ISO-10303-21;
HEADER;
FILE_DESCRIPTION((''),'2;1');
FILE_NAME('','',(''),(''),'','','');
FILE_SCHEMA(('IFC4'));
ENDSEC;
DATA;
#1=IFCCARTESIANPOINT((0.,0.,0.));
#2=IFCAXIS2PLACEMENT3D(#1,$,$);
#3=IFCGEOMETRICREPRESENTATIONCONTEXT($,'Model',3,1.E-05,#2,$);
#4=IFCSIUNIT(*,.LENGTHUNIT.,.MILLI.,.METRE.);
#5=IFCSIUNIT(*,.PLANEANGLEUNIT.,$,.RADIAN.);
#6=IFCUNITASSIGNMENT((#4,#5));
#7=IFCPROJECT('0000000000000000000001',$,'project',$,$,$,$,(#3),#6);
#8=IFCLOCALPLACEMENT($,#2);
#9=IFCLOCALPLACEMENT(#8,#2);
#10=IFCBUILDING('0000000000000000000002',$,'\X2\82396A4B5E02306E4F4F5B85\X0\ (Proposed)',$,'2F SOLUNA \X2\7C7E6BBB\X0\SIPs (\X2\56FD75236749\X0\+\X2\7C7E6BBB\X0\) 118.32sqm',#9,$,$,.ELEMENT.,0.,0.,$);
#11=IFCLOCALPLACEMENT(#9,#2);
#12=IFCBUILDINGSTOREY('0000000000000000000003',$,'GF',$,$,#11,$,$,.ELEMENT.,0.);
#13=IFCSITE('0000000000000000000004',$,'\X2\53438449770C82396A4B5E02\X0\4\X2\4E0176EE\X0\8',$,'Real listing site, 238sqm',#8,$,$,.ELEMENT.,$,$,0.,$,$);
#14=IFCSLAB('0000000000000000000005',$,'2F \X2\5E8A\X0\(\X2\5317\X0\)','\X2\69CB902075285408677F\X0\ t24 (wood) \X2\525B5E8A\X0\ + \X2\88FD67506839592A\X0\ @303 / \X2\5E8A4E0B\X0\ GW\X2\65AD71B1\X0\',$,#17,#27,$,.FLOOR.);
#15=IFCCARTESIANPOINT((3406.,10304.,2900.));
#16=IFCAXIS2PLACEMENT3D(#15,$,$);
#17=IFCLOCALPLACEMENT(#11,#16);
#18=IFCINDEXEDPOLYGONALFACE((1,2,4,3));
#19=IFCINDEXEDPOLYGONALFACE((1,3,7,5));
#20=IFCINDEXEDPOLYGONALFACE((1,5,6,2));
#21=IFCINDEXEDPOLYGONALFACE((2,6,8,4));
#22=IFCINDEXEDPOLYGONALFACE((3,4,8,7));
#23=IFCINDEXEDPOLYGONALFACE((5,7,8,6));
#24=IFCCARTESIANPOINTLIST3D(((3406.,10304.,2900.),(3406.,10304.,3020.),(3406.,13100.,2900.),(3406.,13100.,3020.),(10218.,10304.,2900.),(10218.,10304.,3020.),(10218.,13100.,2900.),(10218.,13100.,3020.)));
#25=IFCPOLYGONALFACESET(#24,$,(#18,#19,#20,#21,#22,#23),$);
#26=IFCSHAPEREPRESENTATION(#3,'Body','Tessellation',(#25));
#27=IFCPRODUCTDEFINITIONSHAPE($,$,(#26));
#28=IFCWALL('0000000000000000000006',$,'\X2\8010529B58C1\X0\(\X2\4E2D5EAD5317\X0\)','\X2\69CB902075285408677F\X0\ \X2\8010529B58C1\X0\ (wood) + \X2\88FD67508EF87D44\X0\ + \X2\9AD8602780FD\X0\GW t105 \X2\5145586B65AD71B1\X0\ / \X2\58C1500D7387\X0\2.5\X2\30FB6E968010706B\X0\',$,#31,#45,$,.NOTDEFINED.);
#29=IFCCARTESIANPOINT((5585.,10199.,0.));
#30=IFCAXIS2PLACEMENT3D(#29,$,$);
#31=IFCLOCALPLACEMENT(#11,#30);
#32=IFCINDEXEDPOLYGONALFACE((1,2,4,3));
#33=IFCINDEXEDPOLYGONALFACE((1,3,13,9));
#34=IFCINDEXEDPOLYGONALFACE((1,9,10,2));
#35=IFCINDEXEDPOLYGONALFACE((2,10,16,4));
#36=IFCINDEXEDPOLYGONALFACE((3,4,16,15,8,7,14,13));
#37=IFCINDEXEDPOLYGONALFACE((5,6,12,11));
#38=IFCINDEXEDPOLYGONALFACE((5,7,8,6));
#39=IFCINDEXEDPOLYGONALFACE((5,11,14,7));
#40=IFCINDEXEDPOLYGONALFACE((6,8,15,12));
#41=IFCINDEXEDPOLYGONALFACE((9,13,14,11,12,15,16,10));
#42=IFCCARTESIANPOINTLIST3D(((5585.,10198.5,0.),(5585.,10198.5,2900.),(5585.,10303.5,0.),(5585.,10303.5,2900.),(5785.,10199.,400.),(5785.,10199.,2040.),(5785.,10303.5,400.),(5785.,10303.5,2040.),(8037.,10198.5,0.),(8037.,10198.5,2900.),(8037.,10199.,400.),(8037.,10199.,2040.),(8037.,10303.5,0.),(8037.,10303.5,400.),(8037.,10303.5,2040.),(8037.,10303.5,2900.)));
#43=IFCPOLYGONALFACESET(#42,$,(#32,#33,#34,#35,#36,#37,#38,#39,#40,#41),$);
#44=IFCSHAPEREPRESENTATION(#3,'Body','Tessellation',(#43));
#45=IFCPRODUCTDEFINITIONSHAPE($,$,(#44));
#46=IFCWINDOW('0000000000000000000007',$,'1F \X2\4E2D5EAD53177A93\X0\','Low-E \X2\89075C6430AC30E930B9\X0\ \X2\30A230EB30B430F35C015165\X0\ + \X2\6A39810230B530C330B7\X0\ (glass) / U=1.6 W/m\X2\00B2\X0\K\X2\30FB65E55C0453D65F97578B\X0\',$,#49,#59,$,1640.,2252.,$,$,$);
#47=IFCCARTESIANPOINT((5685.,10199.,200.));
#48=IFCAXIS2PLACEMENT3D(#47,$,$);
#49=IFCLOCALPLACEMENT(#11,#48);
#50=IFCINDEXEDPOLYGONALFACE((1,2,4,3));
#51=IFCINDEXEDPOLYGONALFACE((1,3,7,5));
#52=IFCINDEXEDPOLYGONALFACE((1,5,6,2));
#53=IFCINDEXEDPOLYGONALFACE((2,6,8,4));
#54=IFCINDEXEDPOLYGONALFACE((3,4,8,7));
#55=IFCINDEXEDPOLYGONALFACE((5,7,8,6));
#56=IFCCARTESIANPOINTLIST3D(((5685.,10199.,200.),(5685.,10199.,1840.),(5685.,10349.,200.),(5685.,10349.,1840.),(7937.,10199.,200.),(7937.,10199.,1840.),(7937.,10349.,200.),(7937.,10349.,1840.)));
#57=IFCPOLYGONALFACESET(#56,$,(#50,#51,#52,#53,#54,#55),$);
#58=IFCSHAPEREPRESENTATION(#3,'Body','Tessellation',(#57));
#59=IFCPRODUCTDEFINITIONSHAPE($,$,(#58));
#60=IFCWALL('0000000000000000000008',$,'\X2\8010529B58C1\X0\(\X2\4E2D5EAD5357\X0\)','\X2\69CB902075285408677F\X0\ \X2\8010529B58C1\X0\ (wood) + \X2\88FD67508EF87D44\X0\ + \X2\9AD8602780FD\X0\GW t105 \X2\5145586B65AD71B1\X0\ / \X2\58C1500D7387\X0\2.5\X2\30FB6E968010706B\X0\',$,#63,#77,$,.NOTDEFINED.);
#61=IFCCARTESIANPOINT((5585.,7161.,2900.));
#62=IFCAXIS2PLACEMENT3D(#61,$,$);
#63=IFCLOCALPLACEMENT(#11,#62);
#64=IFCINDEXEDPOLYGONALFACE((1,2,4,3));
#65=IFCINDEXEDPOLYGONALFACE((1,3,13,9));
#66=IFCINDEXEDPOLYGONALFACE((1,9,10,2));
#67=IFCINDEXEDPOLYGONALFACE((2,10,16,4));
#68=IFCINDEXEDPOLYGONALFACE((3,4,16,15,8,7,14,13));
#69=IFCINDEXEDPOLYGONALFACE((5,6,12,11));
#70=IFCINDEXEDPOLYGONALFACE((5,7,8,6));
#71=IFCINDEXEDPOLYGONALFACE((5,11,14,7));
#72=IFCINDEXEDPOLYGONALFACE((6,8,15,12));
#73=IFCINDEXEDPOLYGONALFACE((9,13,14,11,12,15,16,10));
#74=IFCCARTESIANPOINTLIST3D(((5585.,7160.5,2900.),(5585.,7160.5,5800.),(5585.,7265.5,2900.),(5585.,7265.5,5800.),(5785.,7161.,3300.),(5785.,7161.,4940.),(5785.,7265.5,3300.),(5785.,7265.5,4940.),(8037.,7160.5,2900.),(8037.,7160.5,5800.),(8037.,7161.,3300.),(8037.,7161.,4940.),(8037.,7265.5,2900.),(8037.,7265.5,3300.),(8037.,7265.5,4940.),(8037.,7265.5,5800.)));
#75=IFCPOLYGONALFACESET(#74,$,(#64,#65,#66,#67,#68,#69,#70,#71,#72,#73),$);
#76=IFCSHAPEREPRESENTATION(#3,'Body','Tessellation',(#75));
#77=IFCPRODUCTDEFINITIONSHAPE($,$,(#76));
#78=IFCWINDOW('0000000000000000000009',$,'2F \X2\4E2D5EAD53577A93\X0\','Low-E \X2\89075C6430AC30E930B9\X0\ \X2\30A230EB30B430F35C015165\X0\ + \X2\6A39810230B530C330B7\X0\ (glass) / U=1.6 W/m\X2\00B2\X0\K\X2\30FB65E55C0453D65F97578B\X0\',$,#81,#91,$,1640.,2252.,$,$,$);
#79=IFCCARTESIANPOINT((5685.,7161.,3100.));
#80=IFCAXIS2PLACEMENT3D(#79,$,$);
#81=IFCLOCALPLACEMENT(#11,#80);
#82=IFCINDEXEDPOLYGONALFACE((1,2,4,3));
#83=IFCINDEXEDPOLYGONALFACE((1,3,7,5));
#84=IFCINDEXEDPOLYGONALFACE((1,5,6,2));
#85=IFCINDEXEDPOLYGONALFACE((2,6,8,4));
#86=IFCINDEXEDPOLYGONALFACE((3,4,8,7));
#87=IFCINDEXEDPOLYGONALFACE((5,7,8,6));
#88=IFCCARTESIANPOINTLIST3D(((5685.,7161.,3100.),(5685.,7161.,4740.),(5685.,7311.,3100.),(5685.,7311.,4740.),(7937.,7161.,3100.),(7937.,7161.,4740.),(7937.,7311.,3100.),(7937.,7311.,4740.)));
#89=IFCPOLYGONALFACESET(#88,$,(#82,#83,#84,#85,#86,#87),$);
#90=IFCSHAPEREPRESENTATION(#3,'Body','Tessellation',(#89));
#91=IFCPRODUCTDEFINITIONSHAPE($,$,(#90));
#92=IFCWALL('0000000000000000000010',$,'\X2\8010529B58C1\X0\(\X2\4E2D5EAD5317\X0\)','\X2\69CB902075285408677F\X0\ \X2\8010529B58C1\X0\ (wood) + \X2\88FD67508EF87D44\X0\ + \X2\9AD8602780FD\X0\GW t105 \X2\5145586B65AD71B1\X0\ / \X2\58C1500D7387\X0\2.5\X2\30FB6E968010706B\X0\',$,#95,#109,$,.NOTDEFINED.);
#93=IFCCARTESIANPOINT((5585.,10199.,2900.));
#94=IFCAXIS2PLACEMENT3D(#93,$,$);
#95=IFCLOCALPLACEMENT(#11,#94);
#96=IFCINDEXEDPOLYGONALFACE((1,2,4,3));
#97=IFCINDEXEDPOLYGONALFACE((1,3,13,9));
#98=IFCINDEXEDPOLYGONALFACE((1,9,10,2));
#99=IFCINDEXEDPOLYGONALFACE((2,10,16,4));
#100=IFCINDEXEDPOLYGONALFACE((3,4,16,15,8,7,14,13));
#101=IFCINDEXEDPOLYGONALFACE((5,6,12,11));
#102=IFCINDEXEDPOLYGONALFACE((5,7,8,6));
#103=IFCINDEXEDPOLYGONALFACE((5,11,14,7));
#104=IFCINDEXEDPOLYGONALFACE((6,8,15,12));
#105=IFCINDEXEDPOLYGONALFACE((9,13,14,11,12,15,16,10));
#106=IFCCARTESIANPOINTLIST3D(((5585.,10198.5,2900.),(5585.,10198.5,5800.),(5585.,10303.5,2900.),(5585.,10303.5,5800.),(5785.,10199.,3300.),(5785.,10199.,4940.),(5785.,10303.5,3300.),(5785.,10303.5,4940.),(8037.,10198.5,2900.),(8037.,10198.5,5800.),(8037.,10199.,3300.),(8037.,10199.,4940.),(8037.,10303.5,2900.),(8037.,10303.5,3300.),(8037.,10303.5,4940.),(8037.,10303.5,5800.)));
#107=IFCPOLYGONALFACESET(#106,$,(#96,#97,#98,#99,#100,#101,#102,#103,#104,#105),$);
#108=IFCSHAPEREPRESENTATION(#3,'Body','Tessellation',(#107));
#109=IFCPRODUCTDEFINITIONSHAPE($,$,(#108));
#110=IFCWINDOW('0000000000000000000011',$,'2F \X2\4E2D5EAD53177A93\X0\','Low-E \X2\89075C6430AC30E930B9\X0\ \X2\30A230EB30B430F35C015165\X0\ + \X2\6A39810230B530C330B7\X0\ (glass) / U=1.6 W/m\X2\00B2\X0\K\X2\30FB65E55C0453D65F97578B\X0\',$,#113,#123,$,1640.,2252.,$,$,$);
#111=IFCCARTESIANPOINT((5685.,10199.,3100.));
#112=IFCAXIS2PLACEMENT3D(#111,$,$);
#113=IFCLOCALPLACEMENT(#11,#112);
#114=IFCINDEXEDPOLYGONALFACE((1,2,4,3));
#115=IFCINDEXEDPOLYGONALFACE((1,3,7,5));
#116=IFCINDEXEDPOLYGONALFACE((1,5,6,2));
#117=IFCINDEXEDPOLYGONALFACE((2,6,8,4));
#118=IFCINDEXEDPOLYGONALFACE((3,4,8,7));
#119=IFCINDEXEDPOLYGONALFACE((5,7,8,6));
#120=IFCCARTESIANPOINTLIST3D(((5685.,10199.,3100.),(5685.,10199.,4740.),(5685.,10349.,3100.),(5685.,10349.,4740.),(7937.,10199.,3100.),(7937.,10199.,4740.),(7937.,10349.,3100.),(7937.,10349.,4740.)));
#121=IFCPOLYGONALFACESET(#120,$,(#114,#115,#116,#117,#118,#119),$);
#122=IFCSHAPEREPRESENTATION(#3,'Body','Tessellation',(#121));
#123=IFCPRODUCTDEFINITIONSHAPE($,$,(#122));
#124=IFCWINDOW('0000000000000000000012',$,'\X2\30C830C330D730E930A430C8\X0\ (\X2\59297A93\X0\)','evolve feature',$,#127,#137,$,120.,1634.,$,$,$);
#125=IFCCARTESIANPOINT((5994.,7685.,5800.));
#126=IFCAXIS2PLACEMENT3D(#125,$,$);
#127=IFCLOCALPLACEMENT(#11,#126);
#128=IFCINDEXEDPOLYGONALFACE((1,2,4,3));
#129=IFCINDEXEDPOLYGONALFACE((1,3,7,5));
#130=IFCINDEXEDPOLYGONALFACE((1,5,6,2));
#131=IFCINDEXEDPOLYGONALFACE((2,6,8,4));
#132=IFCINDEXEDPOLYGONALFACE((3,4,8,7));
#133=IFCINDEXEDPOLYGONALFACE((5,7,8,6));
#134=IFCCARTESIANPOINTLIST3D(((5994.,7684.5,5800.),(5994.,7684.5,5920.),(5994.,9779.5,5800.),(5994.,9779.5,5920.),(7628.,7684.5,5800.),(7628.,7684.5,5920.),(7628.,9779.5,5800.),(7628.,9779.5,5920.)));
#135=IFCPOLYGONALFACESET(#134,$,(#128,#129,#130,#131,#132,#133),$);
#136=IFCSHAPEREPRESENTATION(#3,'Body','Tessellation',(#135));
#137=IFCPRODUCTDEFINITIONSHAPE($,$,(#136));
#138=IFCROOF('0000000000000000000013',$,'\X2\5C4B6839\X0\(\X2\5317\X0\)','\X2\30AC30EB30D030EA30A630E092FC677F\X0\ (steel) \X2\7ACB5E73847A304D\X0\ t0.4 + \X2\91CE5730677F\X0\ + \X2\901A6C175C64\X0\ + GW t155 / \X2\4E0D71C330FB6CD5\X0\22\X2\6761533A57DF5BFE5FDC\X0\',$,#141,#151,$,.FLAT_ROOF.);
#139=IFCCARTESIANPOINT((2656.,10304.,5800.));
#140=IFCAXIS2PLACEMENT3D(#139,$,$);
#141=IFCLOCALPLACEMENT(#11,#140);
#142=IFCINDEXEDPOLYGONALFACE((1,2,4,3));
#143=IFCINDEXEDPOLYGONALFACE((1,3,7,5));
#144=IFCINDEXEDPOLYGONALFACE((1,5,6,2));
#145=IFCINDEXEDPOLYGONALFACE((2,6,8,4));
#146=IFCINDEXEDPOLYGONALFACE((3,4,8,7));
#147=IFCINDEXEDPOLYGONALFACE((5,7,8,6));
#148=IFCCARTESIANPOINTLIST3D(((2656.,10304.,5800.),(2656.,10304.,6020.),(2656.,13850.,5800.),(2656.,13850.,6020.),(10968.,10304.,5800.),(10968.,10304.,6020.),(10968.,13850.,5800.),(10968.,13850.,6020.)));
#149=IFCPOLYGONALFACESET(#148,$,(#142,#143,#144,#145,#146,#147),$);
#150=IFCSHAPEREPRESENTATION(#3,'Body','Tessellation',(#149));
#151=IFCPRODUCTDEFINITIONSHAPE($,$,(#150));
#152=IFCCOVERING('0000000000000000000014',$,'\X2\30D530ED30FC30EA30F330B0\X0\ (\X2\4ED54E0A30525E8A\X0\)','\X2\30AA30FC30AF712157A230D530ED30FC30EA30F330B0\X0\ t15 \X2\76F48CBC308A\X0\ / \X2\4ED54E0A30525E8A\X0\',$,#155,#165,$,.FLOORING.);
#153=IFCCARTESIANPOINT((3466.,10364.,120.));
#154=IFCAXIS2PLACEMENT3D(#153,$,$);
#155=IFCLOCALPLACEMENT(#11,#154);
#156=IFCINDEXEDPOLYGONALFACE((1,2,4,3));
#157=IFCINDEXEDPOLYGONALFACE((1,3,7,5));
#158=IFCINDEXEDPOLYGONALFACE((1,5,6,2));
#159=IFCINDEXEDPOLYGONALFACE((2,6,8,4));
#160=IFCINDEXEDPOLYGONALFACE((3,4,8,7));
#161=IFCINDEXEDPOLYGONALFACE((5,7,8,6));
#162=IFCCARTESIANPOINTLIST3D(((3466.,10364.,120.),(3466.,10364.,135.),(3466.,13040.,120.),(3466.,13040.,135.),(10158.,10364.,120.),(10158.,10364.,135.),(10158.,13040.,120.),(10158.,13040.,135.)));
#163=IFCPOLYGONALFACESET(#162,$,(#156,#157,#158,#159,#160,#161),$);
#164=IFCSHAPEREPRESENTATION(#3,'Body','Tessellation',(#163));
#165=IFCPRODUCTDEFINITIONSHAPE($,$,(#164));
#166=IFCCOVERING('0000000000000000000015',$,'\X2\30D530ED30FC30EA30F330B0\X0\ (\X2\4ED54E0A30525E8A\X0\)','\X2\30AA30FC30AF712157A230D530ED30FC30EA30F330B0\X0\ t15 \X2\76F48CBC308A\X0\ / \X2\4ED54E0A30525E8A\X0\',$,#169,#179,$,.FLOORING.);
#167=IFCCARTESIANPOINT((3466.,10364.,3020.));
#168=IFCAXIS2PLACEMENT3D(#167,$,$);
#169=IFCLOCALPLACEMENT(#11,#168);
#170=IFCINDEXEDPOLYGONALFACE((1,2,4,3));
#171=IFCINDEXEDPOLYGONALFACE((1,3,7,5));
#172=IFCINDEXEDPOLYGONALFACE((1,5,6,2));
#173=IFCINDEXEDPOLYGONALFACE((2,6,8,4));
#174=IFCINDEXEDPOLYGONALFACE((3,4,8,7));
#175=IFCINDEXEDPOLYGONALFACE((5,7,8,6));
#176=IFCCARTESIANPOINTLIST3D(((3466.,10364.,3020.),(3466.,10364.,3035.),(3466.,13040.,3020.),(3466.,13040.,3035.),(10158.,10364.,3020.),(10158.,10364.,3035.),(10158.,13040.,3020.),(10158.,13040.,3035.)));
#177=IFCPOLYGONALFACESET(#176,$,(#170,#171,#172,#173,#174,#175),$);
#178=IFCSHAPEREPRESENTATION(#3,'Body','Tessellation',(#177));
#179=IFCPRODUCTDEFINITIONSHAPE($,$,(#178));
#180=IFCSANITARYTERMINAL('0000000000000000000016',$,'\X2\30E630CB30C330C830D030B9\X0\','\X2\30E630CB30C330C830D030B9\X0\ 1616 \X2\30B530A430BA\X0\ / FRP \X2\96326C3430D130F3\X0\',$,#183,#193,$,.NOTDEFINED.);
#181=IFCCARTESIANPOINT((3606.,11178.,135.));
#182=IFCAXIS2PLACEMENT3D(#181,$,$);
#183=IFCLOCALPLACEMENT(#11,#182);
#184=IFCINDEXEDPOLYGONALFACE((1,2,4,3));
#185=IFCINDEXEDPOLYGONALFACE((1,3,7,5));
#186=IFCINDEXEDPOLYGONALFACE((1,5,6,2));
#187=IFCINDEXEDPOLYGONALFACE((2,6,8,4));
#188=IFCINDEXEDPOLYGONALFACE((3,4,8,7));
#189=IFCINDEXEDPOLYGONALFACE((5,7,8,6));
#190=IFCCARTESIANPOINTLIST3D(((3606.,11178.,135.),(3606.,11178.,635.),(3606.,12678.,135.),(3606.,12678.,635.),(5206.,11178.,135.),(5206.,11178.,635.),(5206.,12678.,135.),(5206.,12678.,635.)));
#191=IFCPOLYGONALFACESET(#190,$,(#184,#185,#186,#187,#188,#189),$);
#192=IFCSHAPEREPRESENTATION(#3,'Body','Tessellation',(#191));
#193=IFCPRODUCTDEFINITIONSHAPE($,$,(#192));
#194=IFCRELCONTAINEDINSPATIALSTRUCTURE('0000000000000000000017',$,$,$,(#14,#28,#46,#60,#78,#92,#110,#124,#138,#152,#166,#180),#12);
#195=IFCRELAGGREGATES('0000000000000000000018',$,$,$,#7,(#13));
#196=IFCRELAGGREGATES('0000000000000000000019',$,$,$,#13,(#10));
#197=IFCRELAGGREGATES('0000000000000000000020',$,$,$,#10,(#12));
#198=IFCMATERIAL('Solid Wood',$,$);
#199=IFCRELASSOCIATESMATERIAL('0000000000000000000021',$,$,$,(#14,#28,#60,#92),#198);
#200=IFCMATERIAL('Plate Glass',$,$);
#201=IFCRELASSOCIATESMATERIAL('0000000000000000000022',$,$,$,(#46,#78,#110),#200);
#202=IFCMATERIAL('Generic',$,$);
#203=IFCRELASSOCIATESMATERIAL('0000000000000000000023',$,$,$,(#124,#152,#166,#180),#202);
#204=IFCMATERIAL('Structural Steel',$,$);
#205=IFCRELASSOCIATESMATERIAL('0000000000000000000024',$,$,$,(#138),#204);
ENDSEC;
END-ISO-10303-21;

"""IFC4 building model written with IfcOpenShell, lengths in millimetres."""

from ifc_helpers import new_model, si_unit, frame, frame_2d, origin, place, context, project, spatial, rectangle, extrude, material, element, fill, save


model = new_model("IFC4")

# Units and contexts
model_context = context("Model", 3, precision=1e-05, world=origin())
ifc_project = project(units=[si_unit("LENGTHUNIT", "METRE", prefix="MILLI"), si_unit("PLANEANGLEUNIT", "RADIAN")], contexts=[model_context])

# Site, building, storey
site_placement = place(None, origin())
site = spatial("IfcSite", under=ifc_project, at=site_placement, Name="千葉県船橋市4丁目8", ObjectType="Real listing site, 238sqm", CompositionType="ELEMENT", RefElevation=0.0)
building_placement = place(site_placement, origin())
building = spatial("IfcBuilding", under=site, at=building_placement, Name="船橋市の住宅 (Proposed)", ObjectType="2F SOLUNA 籾殻SIPs (国産杉+籾殻) 118.32sqm", CompositionType="ELEMENT", ElevationOfRefHeight=0.0, ElevationOfTerrain=0.0)
storey_placement = place(building_placement, origin())
storey = spatial("IfcBuildingStorey", under=building, at=storey_placement, Name="GF", CompositionType="ELEMENT", Elevation=0.0)

# Slab
ifc_material_1 = material(Name="Solid Wood")
slab_1_placement = place(storey_placement, frame((3406.0, 10304.0, 2900.0)))
element("IfcSlab", 1, at=slab_1_placement, inside=storey, material=ifc_material_1, Name="2F 床(北)", Description="構造用合板 t24 (wood) 剛床 + 製材根太 @303 / 床下 GW断熱", PredefinedType="FLOOR", context=model_context, shape_type="SweptSolid", body=[
    extrude(rectangle(XDim=6812.0, YDim=2796.0, at=frame_2d((3406.0, 1398.0))), frame((3406.0, 10304.0, 2900.0)), (0.0, 0.0, 1.0), 120.0),
])

# Wall, opening, window
wall_1_placement = place(storey_placement, frame((5585.0, 10199.0, 0.0)))
wall_1 = element("IfcWall", 2, at=wall_1_placement, inside=storey, material=ifc_material_1, Name="耐力壁(中庭北)", Description="構造用合板 耐力壁 (wood) + 製材軸組 + 高性能GW t105 充填断熱 / 壁倍率2.5・準耐火", PredefinedType="NOTDEFINED", context=model_context, shape_type="SweptSolid", body=[
    extrude(rectangle(XDim=2452.0, YDim=105.0, at=frame_2d((1226.0, 52.0))), frame((5585.0, 10199.0, 0.0)), (0.0, 0.0, 1.0), 2900.0),
])
opening_1_placement = place(storey_placement, frame((5685.0, 10199.0, 200.0)))
opening_1 = element("IfcOpeningElement", 3, at=opening_1_placement, cuts=wall_1, PredefinedType="NOTDEFINED", context=model_context, shape_type="SweptSolid", body=[
    extrude(rectangle(XDim=2252.0, YDim=150.0, at=frame_2d((1126.0, 75.0))), frame((5685.0, 10199.0, 200.0)), (0.0, 0.0, 1.0), 1640.0),
])
ifc_material_2 = material(Name="Plate Glass")
window_1_placement = place(storey_placement, frame((5685.0, 10199.0, 200.0)))
window_1 = element("IfcWindow", 4, at=window_1_placement, inside=storey, material=ifc_material_2, Name="1F 中庭北窓", Description="Low-E 複層ガラス アルゴン封入 + 樹脂サッシ (glass) / U=1.6 W/m²K・日射取得型", OverallHeight=1640.0, OverallWidth=2252.0, context=model_context, shape_type="SweptSolid", body=[
    extrude(rectangle(XDim=2252.0, YDim=150.0, at=frame_2d((1126.0, 75.0))), frame((5685.0, 10199.0, 200.0)), (0.0, 0.0, 1.0), 1640.0),
])
fill(opening_1, window_1)

# Walls, openings, windows
wall_2_placement = place(storey_placement, frame((5585.0, 7161.0, 2900.0)))
wall_2 = element("IfcWall", 5, at=wall_2_placement, inside=storey, material=ifc_material_1, Name="耐力壁(中庭南)", Description="構造用合板 耐力壁 (wood) + 製材軸組 + 高性能GW t105 充填断熱 / 壁倍率2.5・準耐火", PredefinedType="NOTDEFINED", context=model_context, shape_type="SweptSolid", body=[
    extrude(rectangle(XDim=2452.0, YDim=105.0, at=frame_2d((1226.0, 52.0))), frame((5585.0, 7161.0, 2900.0)), (0.0, 0.0, 1.0), 2900.0),
])
opening_2_placement = place(storey_placement, frame((5685.0, 7161.0, 3100.0)))
opening_2 = element("IfcOpeningElement", 6, at=opening_2_placement, cuts=wall_2, PredefinedType="NOTDEFINED", context=model_context, shape_type="SweptSolid", body=[
    extrude(rectangle(XDim=2252.0, YDim=150.0, at=frame_2d((1126.0, 75.0))), frame((5685.0, 7161.0, 3100.0)), (0.0, 0.0, 1.0), 1640.0),
])
window_2_placement = place(storey_placement, frame((5685.0, 7161.0, 3100.0)))
window_2 = element("IfcWindow", 7, at=window_2_placement, inside=storey, material=ifc_material_2, Name="2F 中庭南窓", Description="Low-E 複層ガラス アルゴン封入 + 樹脂サッシ (glass) / U=1.6 W/m²K・日射取得型", OverallHeight=1640.0, OverallWidth=2252.0, context=model_context, shape_type="SweptSolid", body=[
    extrude(rectangle(XDim=2252.0, YDim=150.0, at=frame_2d((1126.0, 75.0))), frame((5685.0, 7161.0, 3100.0)), (0.0, 0.0, 1.0), 1640.0),
])
fill(opening_2, window_2)
wall_3_placement = place(storey_placement, frame((5585.0, 10199.0, 2900.0)))
wall_3 = element("IfcWall", 8, at=wall_3_placement, inside=storey, material=ifc_material_1, Name="耐力壁(中庭北)", Description="構造用合板 耐力壁 (wood) + 製材軸組 + 高性能GW t105 充填断熱 / 壁倍率2.5・準耐火", PredefinedType="NOTDEFINED", context=model_context, shape_type="SweptSolid", body=[
    extrude(rectangle(XDim=2452.0, YDim=105.0, at=frame_2d((1226.0, 52.0))), frame((5585.0, 10199.0, 2900.0)), (0.0, 0.0, 1.0), 2900.0),
])
opening_3_placement = place(storey_placement, frame((5685.0, 10199.0, 3100.0)))
opening_3 = element("IfcOpeningElement", 9, at=opening_3_placement, cuts=wall_3, PredefinedType="NOTDEFINED", context=model_context, shape_type="SweptSolid", body=[
    extrude(rectangle(XDim=2252.0, YDim=150.0, at=frame_2d((1126.0, 75.0))), frame((5685.0, 10199.0, 3100.0)), (0.0, 0.0, 1.0), 1640.0),
])
window_3_placement = place(storey_placement, frame((5685.0, 10199.0, 3100.0)))
window_3 = element("IfcWindow", 10, at=window_3_placement, inside=storey, material=ifc_material_2, Name="2F 中庭北窓", Description="Low-E 複層ガラス アルゴン封入 + 樹脂サッシ (glass) / U=1.6 W/m²K・日射取得型", OverallHeight=1640.0, OverallWidth=2252.0, context=model_context, shape_type="SweptSolid", body=[
    extrude(rectangle(XDim=2252.0, YDim=150.0, at=frame_2d((1126.0, 75.0))), frame((5685.0, 10199.0, 3100.0)), (0.0, 0.0, 1.0), 1640.0),
])
fill(opening_3, window_3)

# Window
ifc_material_3 = material(Name="Generic")
window_4_placement = place(storey_placement, frame((5994.0, 7685.0, 5800.0)))
element("IfcWindow", 11, at=window_4_placement, inside=storey, material=ifc_material_3, Name="トップライト (天窓)", Description="evolve feature", OverallHeight=120.0, OverallWidth=1634.0, context=model_context, shape_type="SweptSolid", body=[
    extrude(rectangle(XDim=1634.0, YDim=2095.0, at=frame_2d((817.0, 1047.0))), frame((5994.0, 7685.0, 5800.0)), (0.0, 0.0, 1.0), 120.0),
])

# Roof
ifc_material_4 = material(Name="Structural Steel")
roof_1_placement = place(storey_placement, frame((2656.0, 10304.0, 5800.0)))
element("IfcRoof", 12, at=roof_1_placement, inside=storey, material=ifc_material_4, Name="屋根(北)", Description="ガルバリウム鋼板 (steel) 立平葺き t0.4 + 野地板 + 通気層 + GW t155 / 不燃・法22条区域対応", PredefinedType="FLAT_ROOF", context=model_context, shape_type="SweptSolid", body=[
    extrude(rectangle(XDim=8312.0, YDim=3546.0, at=frame_2d((4156.0, 1773.0))), frame((2656.0, 10304.0, 5800.0)), (0.0, 0.0, 1.0), 220.0),
])

# Coverings
covering_1_placement = place(storey_placement, frame((3466.0, 10364.0, 120.0)))
element("IfcCovering", 13, at=covering_1_placement, inside=storey, material=ifc_material_3, Name="フローリング (仕上げ床)", Description="オーク無垢フローリング t15 直貼り / 仕上げ床", PredefinedType="FLOORING", context=model_context, shape_type="SweptSolid", body=[
    extrude(rectangle(XDim=6692.0, YDim=2676.0, at=frame_2d((3346.0, 1338.0))), frame((3466.0, 10364.0, 120.0)), (0.0, 0.0, 1.0), 15.0),
])
covering_2_placement = place(storey_placement, frame((3466.0, 10364.0, 3020.0)))
element("IfcCovering", 14, at=covering_2_placement, inside=storey, material=ifc_material_3, Name="フローリング (仕上げ床)", Description="オーク無垢フローリング t15 直貼り / 仕上げ床", PredefinedType="FLOORING", context=model_context, shape_type="SweptSolid", body=[
    extrude(rectangle(XDim=6692.0, YDim=2676.0, at=frame_2d((3346.0, 1338.0))), frame((3466.0, 10364.0, 3020.0)), (0.0, 0.0, 1.0), 15.0),
])

# Sanitary terminal
sanitary_terminal_1_placement = place(storey_placement, frame((3606.0, 11178.0, 135.0)))
element("IfcSanitaryTerminal", 15, at=sanitary_terminal_1_placement, inside=storey, material=ifc_material_3, Name="ユニットバス", Description="ユニットバス 1616 サイズ / FRP 防水パン", PredefinedType="NOTDEFINED", context=model_context, shape_type="SweptSolid", body=[
    extrude(rectangle(XDim=1600.0, YDim=1500.0, at=frame_2d((800.0, 750.0))), frame((3606.0, 11178.0, 135.0)), (0.0, 0.0, 1.0), 500.0),
])

save(model, "model.ifc")
